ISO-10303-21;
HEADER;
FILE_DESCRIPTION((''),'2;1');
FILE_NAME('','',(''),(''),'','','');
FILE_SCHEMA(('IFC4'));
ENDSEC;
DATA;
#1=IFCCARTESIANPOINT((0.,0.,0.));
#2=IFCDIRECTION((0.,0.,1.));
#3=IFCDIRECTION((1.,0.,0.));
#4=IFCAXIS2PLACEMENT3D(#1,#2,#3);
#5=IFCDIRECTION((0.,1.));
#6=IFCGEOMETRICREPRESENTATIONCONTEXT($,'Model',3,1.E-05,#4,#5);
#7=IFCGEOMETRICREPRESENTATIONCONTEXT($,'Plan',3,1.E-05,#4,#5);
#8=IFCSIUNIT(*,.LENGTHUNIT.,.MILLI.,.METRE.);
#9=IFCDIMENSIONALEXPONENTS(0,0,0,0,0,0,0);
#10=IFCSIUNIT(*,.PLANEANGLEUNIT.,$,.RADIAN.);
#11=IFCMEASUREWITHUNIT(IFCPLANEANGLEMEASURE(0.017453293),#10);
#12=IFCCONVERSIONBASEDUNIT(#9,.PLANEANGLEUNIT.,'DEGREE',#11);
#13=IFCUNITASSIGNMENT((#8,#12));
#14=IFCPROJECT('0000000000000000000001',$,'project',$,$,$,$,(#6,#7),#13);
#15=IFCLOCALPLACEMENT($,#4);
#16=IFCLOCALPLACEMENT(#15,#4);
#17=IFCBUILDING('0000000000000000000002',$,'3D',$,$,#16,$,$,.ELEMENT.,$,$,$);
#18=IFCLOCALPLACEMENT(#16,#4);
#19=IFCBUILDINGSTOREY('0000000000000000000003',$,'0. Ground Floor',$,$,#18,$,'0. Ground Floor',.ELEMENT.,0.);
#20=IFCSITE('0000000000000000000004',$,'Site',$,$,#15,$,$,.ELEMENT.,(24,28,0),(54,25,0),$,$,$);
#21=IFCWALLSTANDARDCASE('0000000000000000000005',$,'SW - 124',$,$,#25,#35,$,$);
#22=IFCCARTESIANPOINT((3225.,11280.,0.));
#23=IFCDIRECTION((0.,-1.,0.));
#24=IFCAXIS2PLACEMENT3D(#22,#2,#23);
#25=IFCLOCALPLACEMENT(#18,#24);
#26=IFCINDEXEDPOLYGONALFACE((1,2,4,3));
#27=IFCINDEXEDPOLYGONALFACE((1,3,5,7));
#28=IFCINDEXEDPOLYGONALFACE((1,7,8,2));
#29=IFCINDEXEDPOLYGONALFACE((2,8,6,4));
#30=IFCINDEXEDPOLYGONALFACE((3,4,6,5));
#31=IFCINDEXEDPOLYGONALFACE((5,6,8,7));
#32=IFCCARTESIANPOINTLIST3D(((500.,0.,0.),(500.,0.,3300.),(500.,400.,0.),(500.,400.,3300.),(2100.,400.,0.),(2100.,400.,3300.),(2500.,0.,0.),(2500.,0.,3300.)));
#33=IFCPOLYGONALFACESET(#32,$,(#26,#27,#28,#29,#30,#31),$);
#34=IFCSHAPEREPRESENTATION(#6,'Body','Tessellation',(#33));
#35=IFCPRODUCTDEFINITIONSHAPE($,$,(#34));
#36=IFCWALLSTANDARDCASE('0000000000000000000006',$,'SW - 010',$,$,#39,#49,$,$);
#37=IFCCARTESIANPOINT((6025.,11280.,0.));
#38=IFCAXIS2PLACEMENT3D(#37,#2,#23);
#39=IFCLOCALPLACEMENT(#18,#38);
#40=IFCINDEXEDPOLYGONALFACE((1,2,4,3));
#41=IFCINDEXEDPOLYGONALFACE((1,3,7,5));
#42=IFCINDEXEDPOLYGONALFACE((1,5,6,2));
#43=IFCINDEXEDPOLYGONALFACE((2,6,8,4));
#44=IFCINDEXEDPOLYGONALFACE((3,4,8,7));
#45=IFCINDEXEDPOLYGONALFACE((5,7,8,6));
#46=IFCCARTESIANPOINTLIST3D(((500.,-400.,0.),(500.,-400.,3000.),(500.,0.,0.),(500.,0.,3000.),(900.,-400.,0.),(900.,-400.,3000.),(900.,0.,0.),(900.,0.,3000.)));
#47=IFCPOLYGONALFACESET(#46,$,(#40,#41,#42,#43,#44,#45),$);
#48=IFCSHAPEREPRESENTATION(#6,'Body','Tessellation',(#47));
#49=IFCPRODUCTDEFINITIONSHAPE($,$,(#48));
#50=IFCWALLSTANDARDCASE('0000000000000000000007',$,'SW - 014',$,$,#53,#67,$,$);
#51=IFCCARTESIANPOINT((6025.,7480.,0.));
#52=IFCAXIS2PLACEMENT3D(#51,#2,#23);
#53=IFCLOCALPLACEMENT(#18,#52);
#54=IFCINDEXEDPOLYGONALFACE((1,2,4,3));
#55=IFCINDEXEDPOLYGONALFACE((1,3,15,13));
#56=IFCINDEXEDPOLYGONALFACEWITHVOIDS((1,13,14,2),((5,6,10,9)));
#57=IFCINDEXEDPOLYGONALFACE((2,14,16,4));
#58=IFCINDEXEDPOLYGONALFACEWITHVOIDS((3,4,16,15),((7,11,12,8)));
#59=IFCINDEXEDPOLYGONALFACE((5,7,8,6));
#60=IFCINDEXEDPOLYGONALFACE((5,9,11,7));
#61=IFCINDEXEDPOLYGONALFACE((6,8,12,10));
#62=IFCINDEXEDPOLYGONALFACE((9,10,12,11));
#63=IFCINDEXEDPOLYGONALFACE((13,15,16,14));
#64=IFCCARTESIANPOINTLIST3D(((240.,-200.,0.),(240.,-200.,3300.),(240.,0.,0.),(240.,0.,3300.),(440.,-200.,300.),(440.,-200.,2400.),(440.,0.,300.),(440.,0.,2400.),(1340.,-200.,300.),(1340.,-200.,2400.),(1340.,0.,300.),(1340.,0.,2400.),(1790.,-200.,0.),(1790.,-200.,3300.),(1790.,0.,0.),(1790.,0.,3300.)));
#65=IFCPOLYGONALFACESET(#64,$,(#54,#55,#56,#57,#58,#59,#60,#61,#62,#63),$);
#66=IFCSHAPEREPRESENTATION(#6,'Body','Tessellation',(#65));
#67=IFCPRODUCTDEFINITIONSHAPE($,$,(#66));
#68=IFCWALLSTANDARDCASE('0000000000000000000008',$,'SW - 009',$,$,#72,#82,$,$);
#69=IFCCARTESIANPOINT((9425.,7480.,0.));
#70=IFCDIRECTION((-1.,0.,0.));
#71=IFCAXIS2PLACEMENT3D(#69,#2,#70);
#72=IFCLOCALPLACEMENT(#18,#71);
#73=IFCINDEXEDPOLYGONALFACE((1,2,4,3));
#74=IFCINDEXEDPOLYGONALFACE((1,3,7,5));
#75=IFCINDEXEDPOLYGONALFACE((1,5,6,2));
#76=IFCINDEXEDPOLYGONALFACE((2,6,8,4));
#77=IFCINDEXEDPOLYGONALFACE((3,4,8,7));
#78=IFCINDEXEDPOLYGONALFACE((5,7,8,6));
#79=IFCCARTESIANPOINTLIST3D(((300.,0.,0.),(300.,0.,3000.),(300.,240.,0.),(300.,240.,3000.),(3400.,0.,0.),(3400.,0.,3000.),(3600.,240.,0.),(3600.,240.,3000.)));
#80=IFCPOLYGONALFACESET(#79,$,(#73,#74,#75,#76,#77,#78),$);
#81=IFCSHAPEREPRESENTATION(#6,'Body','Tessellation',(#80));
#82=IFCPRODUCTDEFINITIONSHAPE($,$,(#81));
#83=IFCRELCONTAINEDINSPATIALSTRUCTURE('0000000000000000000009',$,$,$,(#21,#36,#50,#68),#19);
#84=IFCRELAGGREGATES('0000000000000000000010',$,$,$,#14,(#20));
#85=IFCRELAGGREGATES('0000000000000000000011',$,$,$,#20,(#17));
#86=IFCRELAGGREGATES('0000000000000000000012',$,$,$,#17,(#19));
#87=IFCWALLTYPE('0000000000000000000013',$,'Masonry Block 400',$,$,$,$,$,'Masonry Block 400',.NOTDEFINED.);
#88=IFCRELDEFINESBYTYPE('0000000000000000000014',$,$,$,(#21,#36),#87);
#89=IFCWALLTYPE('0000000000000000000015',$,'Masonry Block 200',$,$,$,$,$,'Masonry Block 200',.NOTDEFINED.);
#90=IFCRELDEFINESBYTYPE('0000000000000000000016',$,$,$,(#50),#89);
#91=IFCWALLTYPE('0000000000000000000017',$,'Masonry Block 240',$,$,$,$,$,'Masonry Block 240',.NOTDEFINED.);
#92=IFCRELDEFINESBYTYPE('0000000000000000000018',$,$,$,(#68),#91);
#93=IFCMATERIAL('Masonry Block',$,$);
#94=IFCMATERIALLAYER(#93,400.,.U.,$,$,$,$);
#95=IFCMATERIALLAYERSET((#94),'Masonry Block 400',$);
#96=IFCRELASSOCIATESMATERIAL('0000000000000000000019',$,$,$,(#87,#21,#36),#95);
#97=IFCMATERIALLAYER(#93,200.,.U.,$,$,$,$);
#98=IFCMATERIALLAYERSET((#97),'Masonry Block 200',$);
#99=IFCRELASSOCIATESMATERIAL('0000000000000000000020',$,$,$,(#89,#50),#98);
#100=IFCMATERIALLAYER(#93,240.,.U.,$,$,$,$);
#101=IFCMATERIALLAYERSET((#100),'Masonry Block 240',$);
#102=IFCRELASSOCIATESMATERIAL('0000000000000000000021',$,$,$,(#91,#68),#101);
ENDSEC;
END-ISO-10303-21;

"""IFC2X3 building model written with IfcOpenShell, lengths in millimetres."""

from ifc_helpers import new_model, entity, si_unit, converted_unit, direction, frame, frame_2d, origin_with_axes, place, context, project, spatial, polyline, rectangle, outline, extrude, material, layer, layer_set, layer_usage, type_object, element, save


model = new_model("IFC2X3")

# Units and contexts
model_context = context("Model", 3, precision=1e-05, world=origin_with_axes(), true_north=direction((0.0, 1.0)))
plan_context = context("Plan", 3, precision=1e-05, world=origin_with_axes(), true_north=direction((0.0, 1.0)))
ifc_project = project(units=[si_unit("LENGTHUNIT", "METRE", prefix="MILLI"), converted_unit("PLANEANGLEUNIT", "DEGREE", entity("IfcPlaneAngleMeasure", 0.017453293), si_unit("PLANEANGLEUNIT", "RADIAN"), dimensions=[0, 0, 0, 0, 0, 0, 0])], contexts=[model_context, plan_context])

# Site, building, storey
site_placement = place(None, origin_with_axes())
site = spatial("IfcSite", under=ifc_project, at=site_placement, Name="Site", CompositionType="ELEMENT", RefLatitude=(24, 28, 0), RefLongitude=(54, 25, 0))
building_placement = place(site_placement, origin_with_axes())
building = spatial("IfcBuilding", under=site, at=building_placement, Name="3D", CompositionType="ELEMENT")
storey_placement = place(building_placement, origin_with_axes())
storey = spatial("IfcBuildingStorey", under=building, at=storey_placement, Name="0. Ground Floor", LongName="0. Ground Floor", CompositionType="ELEMENT", Elevation=0.0)

# Shared definitions
ifc_material_1 = material(Name="Masonry Block")
ifc_layer_1 = layer(ifc_material_1, 200.0, ventilated="UNKNOWN")
ifc_layer_set_1 = layer_set([ifc_layer_1], Name="Masonry Block 200")

# Walls
ifc_layer_2 = layer(ifc_material_1, 400.0, ventilated="UNKNOWN")
ifc_layer_set_2 = layer_set([ifc_layer_2], Name="Masonry Block 400")
ifc_layer_usage_1 = layer_usage(ifc_layer_set_2, "AXIS2", "POSITIVE", 0.0)
wall_type_1 = type_object("IfcWallType", Name="Masonry Block 400", ElementType="Masonry Block 400", PredefinedType="NOTDEFINED", material=ifc_layer_set_2)
wall_1_placement = place(storey_placement, frame((3225.0, 11280.0, 0.0), z_axis=(0.0, 0.0, 1.0), x_axis=(0.0, -1.0, 0.0)))
element("IfcWallStandardCase", 1, at=wall_1_placement, inside=storey, type_object=wall_type_1, material=ifc_layer_usage_1, Name="SW - 124", context=model_context, shape_type="SweptSolid", body=[
    extrude(outline(polyline([(500.0, 0.0), (2500.0, 0.0), (2100.0, 400.0), (500.0, 400.0), (500.0, 0.0)])), origin_with_axes(), (0.0, 0.0, 1.0), 3300.0),
])
ifc_layer_usage_2 = layer_usage(ifc_layer_set_2, "AXIS2", "NEGATIVE", 0.0)
wall_2_placement = place(storey_placement, frame((6025.0, 11280.0, 0.0), z_axis=(0.0, 0.0, 1.0), x_axis=(0.0, -1.0, 0.0)))
element("IfcWallStandardCase", 2, at=wall_2_placement, inside=storey, type_object=wall_type_1, material=ifc_layer_usage_2, Name="SW - 010", context=model_context, shape_type="SweptSolid", body=[
    extrude(outline(polyline([(500.0, -400.0), (900.0, -400.0), (900.0, 0.0), (500.0, 0.0), (500.0, -400.0)])), origin_with_axes(), (0.0, 0.0, 1.0), 3000.0),
])
wall_type_2 = type_object("IfcWallType", Name="Masonry Block 200", ElementType="Masonry Block 200", PredefinedType="NOTDEFINED", material=ifc_layer_set_1)

# Wall, opening
ifc_layer_usage_3 = layer_usage(ifc_layer_set_1, "AXIS2", "NEGATIVE", 0.0)
wall_3_placement = place(storey_placement, frame((6025.0, 7480.0, 0.0), z_axis=(0.0, 0.0, 1.0), x_axis=(0.0, -1.0, 0.0)))
wall_3 = element("IfcWallStandardCase", 3, at=wall_3_placement, inside=storey, type_object=wall_type_2, material=ifc_layer_usage_3, Name="SW - 014", context=model_context, shape_type="SweptSolid", body=[
    extrude(outline(polyline([(240.0, -200.0), (1790.0, -200.0), (1790.0, 0.0), (240.0, 0.0), (240.0, -200.0)])), origin_with_axes(), (0.0, 0.0, 1.0), 3300.0),
])
opening_1_placement = place(wall_3_placement, frame((890.0, -200.0, 300.0), z_axis=(0.0, 0.0, 1.0), x_axis=(1.0, 0.0, 0.0)))
element("IfcOpeningElement", 4, at=opening_1_placement, cuts=wall_3, ObjectType="Opening", context=model_context, shape_type="SweptSolid", body=[
    extrude(rectangle(XDim=900.0, YDim=2100.0, at=frame_2d((0.0, 1050.0), x_axis=(1.0, 0.0))), frame((0.0, 0.0, 0.0), z_axis=(0.0, 1.0, 0.0), x_axis=(-1.0, 0.0, 0.0)), (0.0, 0.0, 1.0), 200.0),
])

# Wall
ifc_layer_3 = layer(ifc_material_1, 240.0, ventilated="UNKNOWN")
ifc_layer_set_3 = layer_set([ifc_layer_3], Name="Masonry Block 240")
ifc_layer_usage_4 = layer_usage(ifc_layer_set_3, "AXIS2", "POSITIVE", 0.0)
wall_type_3 = type_object("IfcWallType", Name="Masonry Block 240", ElementType="Masonry Block 240", PredefinedType="NOTDEFINED", material=ifc_layer_set_3)
wall_4_placement = place(storey_placement, frame((9425.0, 7480.0, 0.0), z_axis=(0.0, 0.0, 1.0), x_axis=(-1.0, 0.0, 0.0)))
element("IfcWallStandardCase", 5, at=wall_4_placement, inside=storey, type_object=wall_type_3, material=ifc_layer_usage_4, Name="SW - 009", context=model_context, shape_type="SweptSolid", body=[
    extrude(outline(polyline([(300.0, 0.0), (3400.0, 0.0), (3600.0, 240.0), (300.0, 240.0), (300.0, 0.0)])), origin_with_axes(), (0.0, 0.0, 1.0), 3000.0),
])

save(model, "model.ifc")
